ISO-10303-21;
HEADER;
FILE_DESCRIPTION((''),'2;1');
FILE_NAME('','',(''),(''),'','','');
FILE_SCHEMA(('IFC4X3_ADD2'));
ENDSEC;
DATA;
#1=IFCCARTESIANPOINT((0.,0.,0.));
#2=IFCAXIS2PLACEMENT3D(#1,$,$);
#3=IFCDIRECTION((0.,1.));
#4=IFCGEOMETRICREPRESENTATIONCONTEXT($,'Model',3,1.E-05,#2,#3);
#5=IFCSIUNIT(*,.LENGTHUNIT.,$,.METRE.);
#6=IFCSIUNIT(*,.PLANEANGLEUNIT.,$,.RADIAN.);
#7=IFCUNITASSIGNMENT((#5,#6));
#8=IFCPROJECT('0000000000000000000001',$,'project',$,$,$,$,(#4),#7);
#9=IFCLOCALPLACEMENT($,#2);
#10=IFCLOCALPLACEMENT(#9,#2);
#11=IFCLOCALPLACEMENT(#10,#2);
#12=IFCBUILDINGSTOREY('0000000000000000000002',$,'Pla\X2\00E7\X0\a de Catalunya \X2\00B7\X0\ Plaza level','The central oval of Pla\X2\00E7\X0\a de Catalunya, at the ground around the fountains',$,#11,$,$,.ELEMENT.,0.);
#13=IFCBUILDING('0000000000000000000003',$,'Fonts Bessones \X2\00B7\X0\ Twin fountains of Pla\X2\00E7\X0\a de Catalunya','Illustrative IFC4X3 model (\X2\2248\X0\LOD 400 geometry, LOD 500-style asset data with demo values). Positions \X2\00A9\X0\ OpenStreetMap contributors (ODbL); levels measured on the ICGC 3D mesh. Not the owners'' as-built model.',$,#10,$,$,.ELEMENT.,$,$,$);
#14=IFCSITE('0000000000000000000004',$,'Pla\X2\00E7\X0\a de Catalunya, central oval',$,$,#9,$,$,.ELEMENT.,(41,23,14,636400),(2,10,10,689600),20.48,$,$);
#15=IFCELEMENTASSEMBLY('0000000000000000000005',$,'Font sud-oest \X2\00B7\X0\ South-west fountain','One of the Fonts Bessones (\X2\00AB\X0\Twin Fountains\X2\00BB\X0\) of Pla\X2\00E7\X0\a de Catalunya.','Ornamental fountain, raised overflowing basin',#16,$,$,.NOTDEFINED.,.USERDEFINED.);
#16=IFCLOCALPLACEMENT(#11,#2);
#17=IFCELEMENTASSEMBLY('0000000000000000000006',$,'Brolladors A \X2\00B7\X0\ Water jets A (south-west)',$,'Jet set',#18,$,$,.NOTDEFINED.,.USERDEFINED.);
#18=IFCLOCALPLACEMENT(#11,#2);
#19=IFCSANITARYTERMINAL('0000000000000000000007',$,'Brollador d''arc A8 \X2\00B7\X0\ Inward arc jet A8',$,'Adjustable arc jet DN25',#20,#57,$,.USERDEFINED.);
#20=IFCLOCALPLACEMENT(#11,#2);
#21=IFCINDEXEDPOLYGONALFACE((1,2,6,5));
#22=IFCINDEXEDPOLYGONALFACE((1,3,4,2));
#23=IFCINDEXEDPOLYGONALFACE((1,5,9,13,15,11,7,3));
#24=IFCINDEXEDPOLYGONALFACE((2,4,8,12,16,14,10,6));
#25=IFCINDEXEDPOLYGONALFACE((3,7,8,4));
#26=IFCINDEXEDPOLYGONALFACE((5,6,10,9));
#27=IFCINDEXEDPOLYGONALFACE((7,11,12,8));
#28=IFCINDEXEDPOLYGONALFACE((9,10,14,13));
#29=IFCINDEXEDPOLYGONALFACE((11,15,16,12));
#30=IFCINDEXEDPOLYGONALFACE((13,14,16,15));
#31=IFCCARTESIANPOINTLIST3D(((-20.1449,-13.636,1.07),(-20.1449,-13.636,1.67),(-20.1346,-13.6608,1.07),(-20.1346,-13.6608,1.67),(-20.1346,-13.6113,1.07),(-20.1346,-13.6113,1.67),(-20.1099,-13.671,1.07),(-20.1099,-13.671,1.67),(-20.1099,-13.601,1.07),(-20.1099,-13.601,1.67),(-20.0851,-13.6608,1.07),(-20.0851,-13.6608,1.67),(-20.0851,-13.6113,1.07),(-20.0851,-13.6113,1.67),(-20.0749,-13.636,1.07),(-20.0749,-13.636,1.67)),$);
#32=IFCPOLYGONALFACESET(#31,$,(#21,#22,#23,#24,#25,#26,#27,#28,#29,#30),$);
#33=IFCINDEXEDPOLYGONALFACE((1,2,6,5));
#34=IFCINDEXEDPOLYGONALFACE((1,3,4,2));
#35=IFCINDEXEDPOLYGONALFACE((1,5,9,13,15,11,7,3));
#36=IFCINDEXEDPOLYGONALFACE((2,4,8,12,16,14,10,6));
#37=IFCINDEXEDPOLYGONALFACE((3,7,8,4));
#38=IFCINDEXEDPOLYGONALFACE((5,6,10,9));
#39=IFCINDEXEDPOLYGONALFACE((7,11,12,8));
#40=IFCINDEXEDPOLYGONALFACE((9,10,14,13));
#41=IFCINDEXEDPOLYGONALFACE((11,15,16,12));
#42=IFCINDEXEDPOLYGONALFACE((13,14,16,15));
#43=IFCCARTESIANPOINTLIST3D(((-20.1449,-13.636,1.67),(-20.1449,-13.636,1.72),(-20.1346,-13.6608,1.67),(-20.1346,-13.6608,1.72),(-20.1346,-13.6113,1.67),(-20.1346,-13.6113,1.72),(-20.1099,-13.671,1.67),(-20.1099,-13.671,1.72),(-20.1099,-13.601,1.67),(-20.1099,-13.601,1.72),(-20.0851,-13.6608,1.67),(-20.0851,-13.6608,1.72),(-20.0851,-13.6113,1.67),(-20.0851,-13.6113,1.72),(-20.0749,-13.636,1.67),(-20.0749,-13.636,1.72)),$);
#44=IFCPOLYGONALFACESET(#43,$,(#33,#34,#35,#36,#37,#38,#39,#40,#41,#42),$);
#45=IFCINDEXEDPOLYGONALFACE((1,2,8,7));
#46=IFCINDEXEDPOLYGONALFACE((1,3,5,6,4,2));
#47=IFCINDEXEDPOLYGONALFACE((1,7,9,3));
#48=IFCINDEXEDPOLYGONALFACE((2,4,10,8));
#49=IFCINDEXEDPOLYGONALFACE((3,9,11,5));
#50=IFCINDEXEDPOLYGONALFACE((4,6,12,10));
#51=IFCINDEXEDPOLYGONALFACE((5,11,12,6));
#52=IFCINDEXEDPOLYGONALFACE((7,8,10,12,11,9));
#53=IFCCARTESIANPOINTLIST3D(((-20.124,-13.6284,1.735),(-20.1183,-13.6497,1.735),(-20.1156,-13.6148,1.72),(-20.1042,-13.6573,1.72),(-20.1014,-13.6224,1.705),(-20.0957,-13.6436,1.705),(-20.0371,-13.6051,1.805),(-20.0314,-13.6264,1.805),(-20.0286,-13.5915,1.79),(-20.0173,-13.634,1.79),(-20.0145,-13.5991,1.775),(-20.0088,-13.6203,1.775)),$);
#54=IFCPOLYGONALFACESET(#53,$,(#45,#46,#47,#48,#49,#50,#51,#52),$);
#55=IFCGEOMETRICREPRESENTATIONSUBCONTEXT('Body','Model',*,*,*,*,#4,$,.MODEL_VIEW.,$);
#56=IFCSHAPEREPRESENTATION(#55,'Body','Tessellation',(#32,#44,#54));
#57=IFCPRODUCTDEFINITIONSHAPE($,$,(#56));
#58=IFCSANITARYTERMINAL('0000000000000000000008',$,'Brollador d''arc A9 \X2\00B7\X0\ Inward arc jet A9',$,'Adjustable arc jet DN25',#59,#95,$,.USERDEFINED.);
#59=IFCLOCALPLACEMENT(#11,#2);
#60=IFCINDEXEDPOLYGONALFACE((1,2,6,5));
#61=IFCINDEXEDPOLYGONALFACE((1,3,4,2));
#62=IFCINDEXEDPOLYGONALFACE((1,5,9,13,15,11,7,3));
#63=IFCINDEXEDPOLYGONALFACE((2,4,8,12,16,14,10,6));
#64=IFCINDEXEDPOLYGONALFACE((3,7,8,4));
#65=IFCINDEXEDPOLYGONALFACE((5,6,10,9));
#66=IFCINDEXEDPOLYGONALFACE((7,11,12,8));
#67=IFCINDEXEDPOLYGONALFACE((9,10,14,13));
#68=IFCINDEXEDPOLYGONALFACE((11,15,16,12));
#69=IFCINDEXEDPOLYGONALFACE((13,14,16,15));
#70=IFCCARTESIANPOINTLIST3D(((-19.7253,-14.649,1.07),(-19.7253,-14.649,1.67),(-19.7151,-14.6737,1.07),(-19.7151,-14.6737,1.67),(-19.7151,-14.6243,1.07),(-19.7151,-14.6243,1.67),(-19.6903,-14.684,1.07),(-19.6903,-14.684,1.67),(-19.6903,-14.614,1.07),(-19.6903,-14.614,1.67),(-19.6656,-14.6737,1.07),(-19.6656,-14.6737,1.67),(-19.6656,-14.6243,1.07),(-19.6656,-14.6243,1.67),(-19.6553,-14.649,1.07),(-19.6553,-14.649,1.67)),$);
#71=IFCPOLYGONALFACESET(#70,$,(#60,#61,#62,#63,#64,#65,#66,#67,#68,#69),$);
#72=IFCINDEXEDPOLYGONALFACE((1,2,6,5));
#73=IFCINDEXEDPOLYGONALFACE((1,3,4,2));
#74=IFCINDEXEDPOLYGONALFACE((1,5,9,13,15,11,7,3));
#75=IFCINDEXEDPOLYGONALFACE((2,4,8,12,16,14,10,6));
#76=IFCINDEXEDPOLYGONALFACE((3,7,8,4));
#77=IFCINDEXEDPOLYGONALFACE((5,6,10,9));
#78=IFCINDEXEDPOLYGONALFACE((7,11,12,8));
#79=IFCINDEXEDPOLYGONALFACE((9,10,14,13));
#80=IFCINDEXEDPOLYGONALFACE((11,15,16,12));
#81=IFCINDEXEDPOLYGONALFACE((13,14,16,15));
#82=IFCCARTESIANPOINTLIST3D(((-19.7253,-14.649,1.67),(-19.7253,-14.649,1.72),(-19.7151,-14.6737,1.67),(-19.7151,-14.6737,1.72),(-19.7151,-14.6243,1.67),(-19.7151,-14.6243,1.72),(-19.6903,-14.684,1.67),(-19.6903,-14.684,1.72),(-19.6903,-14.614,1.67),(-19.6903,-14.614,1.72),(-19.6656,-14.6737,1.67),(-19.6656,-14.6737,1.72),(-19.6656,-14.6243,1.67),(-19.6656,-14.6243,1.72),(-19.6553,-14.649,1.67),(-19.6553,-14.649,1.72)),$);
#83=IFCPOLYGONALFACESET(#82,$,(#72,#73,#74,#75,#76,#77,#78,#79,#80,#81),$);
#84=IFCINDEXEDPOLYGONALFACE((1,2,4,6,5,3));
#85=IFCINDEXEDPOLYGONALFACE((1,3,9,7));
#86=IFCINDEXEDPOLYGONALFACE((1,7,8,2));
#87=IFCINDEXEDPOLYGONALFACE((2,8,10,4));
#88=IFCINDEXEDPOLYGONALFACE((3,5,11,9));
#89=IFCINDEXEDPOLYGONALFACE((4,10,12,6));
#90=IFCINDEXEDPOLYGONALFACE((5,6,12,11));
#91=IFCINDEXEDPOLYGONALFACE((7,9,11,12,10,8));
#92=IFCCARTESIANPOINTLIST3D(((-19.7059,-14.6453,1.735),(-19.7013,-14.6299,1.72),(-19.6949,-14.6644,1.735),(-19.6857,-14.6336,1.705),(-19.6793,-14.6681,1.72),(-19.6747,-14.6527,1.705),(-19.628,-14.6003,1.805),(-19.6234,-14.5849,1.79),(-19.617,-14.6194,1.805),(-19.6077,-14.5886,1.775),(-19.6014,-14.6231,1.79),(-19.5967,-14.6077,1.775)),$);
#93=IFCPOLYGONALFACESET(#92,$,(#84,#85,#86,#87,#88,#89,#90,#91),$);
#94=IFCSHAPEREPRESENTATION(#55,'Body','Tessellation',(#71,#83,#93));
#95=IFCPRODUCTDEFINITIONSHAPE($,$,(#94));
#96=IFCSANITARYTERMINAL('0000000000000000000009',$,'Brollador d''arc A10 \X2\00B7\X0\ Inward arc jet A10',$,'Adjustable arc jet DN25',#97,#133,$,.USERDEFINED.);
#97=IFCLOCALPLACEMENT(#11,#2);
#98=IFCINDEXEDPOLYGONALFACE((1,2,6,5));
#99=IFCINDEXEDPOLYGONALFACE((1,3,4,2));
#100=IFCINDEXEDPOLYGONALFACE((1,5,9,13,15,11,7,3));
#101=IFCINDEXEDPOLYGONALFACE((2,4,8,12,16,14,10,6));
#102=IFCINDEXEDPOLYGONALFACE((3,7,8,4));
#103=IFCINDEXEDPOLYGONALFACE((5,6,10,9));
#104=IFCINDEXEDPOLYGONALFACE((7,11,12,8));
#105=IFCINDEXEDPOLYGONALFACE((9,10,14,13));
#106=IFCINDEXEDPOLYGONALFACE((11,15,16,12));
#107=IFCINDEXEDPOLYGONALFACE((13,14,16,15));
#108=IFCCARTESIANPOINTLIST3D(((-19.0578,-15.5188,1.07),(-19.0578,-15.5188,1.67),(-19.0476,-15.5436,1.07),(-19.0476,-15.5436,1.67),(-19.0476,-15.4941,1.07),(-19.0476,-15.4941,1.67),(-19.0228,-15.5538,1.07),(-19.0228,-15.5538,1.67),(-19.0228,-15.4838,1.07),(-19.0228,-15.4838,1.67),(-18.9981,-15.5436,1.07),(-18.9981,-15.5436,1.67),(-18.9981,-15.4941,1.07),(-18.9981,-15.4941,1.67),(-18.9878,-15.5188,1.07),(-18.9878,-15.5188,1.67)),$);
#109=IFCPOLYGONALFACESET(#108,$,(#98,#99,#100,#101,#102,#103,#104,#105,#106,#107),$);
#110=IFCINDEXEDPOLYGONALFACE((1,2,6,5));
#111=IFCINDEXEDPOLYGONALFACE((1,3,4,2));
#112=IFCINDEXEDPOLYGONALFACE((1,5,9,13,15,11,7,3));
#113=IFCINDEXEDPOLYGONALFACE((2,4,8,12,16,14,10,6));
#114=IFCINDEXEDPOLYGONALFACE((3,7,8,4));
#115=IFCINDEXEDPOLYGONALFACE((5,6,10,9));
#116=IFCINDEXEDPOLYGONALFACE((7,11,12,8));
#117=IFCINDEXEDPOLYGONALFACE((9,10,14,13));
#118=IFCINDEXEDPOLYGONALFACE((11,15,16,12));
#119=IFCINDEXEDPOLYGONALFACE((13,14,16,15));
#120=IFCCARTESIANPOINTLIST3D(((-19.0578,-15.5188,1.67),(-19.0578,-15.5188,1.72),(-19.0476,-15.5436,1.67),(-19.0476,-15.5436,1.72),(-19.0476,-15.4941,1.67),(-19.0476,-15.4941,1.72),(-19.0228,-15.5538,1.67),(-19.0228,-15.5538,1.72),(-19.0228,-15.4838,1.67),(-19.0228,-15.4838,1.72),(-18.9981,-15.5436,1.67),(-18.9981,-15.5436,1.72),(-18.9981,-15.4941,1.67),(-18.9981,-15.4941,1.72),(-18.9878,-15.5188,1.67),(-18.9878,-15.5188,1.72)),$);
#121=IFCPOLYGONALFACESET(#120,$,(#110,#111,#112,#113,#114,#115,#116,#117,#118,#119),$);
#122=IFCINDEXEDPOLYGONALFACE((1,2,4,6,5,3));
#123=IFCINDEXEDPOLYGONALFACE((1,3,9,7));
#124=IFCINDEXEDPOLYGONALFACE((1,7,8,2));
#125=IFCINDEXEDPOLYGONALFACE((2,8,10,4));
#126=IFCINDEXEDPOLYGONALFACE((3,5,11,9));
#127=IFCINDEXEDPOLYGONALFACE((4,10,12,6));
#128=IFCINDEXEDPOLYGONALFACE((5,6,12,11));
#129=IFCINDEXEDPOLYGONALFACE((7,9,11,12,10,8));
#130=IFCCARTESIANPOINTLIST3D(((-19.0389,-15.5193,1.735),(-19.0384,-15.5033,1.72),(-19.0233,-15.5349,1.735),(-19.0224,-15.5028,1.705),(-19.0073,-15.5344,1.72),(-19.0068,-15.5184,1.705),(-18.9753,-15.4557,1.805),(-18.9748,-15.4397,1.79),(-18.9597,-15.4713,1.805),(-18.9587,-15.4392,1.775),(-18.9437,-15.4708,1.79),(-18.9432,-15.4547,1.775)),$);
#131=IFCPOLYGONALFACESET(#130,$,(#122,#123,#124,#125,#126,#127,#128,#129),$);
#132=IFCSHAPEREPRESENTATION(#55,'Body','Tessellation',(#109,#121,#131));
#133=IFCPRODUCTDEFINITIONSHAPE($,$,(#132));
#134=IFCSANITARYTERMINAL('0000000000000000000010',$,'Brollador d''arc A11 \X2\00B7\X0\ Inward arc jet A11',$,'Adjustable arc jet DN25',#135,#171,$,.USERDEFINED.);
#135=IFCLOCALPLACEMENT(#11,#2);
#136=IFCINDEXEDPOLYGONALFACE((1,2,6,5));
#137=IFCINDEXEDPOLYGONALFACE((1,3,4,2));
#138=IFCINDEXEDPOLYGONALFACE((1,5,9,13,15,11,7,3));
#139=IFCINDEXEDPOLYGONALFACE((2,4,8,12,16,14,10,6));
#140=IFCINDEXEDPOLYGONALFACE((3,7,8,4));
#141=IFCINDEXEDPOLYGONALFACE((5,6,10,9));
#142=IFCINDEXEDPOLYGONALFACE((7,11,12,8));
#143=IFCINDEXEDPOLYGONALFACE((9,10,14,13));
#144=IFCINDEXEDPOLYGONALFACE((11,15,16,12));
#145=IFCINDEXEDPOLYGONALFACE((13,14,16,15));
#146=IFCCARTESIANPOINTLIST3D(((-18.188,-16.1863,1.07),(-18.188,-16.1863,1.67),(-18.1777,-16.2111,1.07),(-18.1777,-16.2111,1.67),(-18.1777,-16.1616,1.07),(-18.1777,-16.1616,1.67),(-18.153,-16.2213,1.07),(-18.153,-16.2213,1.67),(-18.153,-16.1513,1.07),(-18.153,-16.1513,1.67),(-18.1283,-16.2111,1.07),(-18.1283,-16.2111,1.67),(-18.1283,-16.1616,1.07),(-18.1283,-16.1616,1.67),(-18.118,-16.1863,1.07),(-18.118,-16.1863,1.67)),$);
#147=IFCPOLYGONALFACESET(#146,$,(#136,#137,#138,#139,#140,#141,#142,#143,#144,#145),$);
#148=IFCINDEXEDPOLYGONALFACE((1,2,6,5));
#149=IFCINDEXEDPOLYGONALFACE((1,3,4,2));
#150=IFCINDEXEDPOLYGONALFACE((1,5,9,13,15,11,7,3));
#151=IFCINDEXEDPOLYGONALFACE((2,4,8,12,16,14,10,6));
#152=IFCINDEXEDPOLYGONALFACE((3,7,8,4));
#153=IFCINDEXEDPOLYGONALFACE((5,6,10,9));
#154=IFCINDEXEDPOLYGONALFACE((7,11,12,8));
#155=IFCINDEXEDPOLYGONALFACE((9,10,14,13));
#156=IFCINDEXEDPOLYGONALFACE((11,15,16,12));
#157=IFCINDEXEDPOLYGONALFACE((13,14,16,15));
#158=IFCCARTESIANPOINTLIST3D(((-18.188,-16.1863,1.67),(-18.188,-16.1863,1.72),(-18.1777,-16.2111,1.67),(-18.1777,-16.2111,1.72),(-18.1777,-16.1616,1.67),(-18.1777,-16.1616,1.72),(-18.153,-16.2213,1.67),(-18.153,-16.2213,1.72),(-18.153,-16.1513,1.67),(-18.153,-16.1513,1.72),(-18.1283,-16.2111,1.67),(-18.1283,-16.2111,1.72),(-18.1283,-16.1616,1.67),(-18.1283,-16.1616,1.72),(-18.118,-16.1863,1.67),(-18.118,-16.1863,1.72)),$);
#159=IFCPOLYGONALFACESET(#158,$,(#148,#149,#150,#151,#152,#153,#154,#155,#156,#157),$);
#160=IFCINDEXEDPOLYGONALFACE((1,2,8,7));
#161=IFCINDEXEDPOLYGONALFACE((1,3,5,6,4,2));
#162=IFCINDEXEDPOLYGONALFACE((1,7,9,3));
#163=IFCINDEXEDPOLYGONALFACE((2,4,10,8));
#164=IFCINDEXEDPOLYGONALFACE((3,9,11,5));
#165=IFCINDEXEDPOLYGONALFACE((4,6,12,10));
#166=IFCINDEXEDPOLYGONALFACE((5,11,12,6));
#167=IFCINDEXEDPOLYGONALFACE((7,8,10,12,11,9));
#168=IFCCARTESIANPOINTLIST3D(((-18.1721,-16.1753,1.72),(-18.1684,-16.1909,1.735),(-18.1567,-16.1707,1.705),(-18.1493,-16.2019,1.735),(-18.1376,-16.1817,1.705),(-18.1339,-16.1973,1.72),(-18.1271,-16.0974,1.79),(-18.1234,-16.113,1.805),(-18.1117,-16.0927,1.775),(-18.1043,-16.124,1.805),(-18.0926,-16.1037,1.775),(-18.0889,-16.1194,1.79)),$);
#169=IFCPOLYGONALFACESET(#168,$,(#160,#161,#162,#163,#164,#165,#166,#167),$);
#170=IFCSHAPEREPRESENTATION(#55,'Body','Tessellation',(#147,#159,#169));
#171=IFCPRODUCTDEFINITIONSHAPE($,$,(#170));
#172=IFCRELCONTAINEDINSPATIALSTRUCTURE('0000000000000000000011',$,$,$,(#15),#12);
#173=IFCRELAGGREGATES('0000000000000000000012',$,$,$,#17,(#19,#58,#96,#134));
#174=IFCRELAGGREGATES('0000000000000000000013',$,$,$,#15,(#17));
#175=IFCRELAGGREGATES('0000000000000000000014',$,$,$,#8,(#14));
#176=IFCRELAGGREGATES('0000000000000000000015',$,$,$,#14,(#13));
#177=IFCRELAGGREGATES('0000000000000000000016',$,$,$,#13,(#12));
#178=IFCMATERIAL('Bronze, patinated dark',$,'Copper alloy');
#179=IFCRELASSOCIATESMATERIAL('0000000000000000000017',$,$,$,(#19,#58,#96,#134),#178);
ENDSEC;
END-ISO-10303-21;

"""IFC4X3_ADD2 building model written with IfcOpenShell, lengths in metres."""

from ifc_helpers import new_model, si_unit, direction, frame, origin, place, context, subcontext, project, spatial, polyline, outline, extrude, material, element, aggregate, save


model = new_model("IFC4X3_ADD2")

# Units and contexts
model_context = context("Model", 3, precision=1e-05, world=origin(), true_north=direction((0.0, 1.0)))
body_context = subcontext(model_context, "Body", "Model", "MODEL_VIEW")
ifc_project = project(units=[si_unit("LENGTHUNIT", "METRE"), si_unit("PLANEANGLEUNIT", "RADIAN")], contexts=[model_context])

# Site, building, storey
site_placement = place(None, origin())
site = spatial("IfcSite", under=ifc_project, at=site_placement, Name="Plaça de Catalunya, central oval", CompositionType="ELEMENT", RefLatitude=(41, 23, 14, 636400), RefLongitude=(2, 10, 10, 689600), RefElevation=20.48)
building_placement = place(site_placement, origin())
building = spatial("IfcBuilding", under=site, at=building_placement, Name="Fonts Bessones · Twin fountains of Plaça de Catalunya", Description="Illustrative IFC4X3 model (≈LOD 400 geometry, LOD 500-style asset data with demo values). Positions © OpenStreetMap contributors (ODbL); levels measured on the ICGC 3D mesh. Not the owners' as-built model.", CompositionType="ELEMENT")
storey_placement = place(building_placement, origin())
storey = spatial("IfcBuildingStorey", under=building, at=storey_placement, Name="Plaça de Catalunya · Plaza level", Description="The central oval of Plaça de Catalunya, at the ground around the fountains", CompositionType="ELEMENT", Elevation=0.0)

# Element assemblies, sanitary terminals
assembly_1_placement = place(building_placement, origin())
assembly_1 = element("IfcElementAssembly", 1, at=assembly_1_placement, inside=storey, Name="Font sud-oest · South-west fountain", Description="One of the Fonts Bessones («Twin Fountains») of Plaça de Catalunya.", ObjectType="Ornamental fountain, raised overflowing basin", AssemblyPlace="NOTDEFINED", PredefinedType="USERDEFINED")
assembly_2_placement = place(building_placement, origin())
assembly_2 = element("IfcElementAssembly", 2, at=assembly_2_placement, Name="Brolladors A · Water jets A (south-west)", ObjectType="Jet set", AssemblyPlace="NOTDEFINED", PredefinedType="USERDEFINED")
ifc_material_1 = material(Name="Bronze, patinated dark", Category="Copper alloy")
sanitary_terminal_1_placement = place(building_placement, origin())
sanitary_terminal_1 = element("IfcSanitaryTerminal", 3, at=sanitary_terminal_1_placement, material=ifc_material_1, Name="Brollador d'arc A8 · Inward arc jet A8", ObjectType="Adjustable arc jet DN25", PredefinedType="USERDEFINED", context=body_context, shape_type="SweptSolid", body=[
    extrude(outline(polyline([(-20.0749, -13.636), (-20.0851, -13.6113), (-20.1099, -13.601), (-20.1346, -13.6113), (-20.1449, -13.636), (-20.1346, -13.6608), (-20.1099, -13.671), (-20.0851, -13.6608), (-20.0749, -13.636)])), frame((0.0, 0.0, 1.07)), (0.0, 0.0, 1.0), 0.6),
    extrude(outline(polyline([(-20.0749, -13.636), (-20.0851, -13.6113), (-20.1099, -13.601), (-20.1346, -13.6113), (-20.1449, -13.636), (-20.1346, -13.6608), (-20.1099, -13.671), (-20.0851, -13.6608), (-20.0749, -13.636)])), frame((0.0, 0.0, 1.67)), (0.0, 0.0, 1.0), 0.05),
    extrude(outline(polyline([(0.022, 0.0), (0.011, 0.0191), (-0.011, 0.0191), (-0.022, 0.0), (-0.011, -0.0191), (0.011, -0.0191), (0.022, 0.0)])), frame((-20.1099, -13.636, 1.72), z_axis=(0.762456, 0.204299, 0.613941), x_axis=(0.258819, -0.965926, 0.0)), (0.0, 0.0, 1.0), 0.114),
])
sanitary_terminal_2_placement = place(building_placement, origin())
sanitary_terminal_2 = element("IfcSanitaryTerminal", 4, at=sanitary_terminal_2_placement, material=ifc_material_1, Name="Brollador d'arc A9 · Inward arc jet A9", ObjectType="Adjustable arc jet DN25", PredefinedType="USERDEFINED", context=body_context, shape_type="SweptSolid", body=[
    extrude(outline(polyline([(-19.6553, -14.649), (-19.6656, -14.6243), (-19.6903, -14.614), (-19.7151, -14.6243), (-19.7253, -14.649), (-19.7151, -14.6737), (-19.6903, -14.684), (-19.6656, -14.6737), (-19.6553, -14.649)])), frame((0.0, 0.0, 1.07)), (0.0, 0.0, 1.0), 0.6),
    extrude(outline(polyline([(-19.6553, -14.649), (-19.6656, -14.6243), (-19.6903, -14.614), (-19.7151, -14.6243), (-19.7253, -14.649), (-19.7151, -14.6737), (-19.6903, -14.684), (-19.6656, -14.6737), (-19.6553, -14.649)])), frame((0.0, 0.0, 1.67)), (0.0, 0.0, 1.0), 0.05),
    extrude(outline(polyline([(0.022, 0.0), (0.011, 0.0191), (-0.011, 0.0191), (-0.022, 0.0), (-0.011, -0.0191), (0.011, -0.0191), (0.022, 0.0)])), frame((-19.6903, -14.649, 1.72), z_axis=(0.683599, 0.394676, 0.613941), x_axis=(0.5, -0.866025, 0.0)), (0.0, 0.0, 1.0), 0.114),
])
sanitary_terminal_3_placement = place(building_placement, origin())
sanitary_terminal_3 = element("IfcSanitaryTerminal", 5, at=sanitary_terminal_3_placement, material=ifc_material_1, Name="Brollador d'arc A10 · Inward arc jet A10", ObjectType="Adjustable arc jet DN25", PredefinedType="USERDEFINED", context=body_context, shape_type="SweptSolid", body=[
    extrude(outline(polyline([(-18.9878, -15.5188), (-18.9981, -15.4941), (-19.0228, -15.4838), (-19.0476, -15.4941), (-19.0578, -15.5188), (-19.0476, -15.5436), (-19.0228, -15.5538), (-18.9981, -15.5436), (-18.9878, -15.5188)])), frame((0.0, 0.0, 1.07)), (0.0, 0.0, 1.0), 0.6),
    extrude(outline(polyline([(-18.9878, -15.5188), (-18.9981, -15.4941), (-19.0228, -15.4838), (-19.0476, -15.4941), (-19.0578, -15.5188), (-19.0476, -15.5436), (-19.0228, -15.5538), (-18.9981, -15.5436), (-18.9878, -15.5188)])), frame((0.0, 0.0, 1.67)), (0.0, 0.0, 1.0), 0.05),
    extrude(outline(polyline([(0.022, 0.0), (0.011, 0.0191), (-0.011, 0.0191), (-0.022, 0.0), (-0.011, -0.0191), (0.011, -0.0191), (0.022, 0.0)])), frame((-19.0228, -15.5188, 1.72), z_axis=(0.558156, 0.558156, 0.613941), x_axis=(0.707107, -0.707107, 0.0)), (0.0, 0.0, 1.0), 0.114),
])
sanitary_terminal_4_placement = place(building_placement, origin())
sanitary_terminal_4 = element("IfcSanitaryTerminal", 6, at=sanitary_terminal_4_placement, material=ifc_material_1, Name="Brollador d'arc A11 · Inward arc jet A11", ObjectType="Adjustable arc jet DN25", PredefinedType="USERDEFINED", context=body_context, shape_type="SweptSolid", body=[
    extrude(outline(polyline([(-18.118, -16.1863), (-18.1283, -16.1616), (-18.153, -16.1513), (-18.1777, -16.1616), (-18.188, -16.1863), (-18.1777, -16.2111), (-18.153, -16.2213), (-18.1283, -16.2111), (-18.118, -16.1863)])), frame((0.0, 0.0, 1.07)), (0.0, 0.0, 1.0), 0.6),
    extrude(outline(polyline([(-18.118, -16.1863), (-18.1283, -16.1616), (-18.153, -16.1513), (-18.1777, -16.1616), (-18.188, -16.1863), (-18.1777, -16.2111), (-18.153, -16.2213), (-18.1283, -16.2111), (-18.118, -16.1863)])), frame((0.0, 0.0, 1.67)), (0.0, 0.0, 1.0), 0.05),
    extrude(outline(polyline([(0.022, 0.0), (0.011, 0.0191), (-0.011, 0.0191), (-0.022, 0.0), (-0.011, -0.0191), (0.011, -0.0191), (0.022, 0.0)])), frame((-18.153, -16.1863, 1.72), z_axis=(0.394676, 0.683599, 0.613941), x_axis=(0.866025, -0.5, 0.0)), (0.0, 0.0, 1.0), 0.114),
])
aggregate(assembly_2, [sanitary_terminal_1, sanitary_terminal_2, sanitary_terminal_3, sanitary_terminal_4])
aggregate(assembly_1, [assembly_2])

save(model, "model.ifc")
